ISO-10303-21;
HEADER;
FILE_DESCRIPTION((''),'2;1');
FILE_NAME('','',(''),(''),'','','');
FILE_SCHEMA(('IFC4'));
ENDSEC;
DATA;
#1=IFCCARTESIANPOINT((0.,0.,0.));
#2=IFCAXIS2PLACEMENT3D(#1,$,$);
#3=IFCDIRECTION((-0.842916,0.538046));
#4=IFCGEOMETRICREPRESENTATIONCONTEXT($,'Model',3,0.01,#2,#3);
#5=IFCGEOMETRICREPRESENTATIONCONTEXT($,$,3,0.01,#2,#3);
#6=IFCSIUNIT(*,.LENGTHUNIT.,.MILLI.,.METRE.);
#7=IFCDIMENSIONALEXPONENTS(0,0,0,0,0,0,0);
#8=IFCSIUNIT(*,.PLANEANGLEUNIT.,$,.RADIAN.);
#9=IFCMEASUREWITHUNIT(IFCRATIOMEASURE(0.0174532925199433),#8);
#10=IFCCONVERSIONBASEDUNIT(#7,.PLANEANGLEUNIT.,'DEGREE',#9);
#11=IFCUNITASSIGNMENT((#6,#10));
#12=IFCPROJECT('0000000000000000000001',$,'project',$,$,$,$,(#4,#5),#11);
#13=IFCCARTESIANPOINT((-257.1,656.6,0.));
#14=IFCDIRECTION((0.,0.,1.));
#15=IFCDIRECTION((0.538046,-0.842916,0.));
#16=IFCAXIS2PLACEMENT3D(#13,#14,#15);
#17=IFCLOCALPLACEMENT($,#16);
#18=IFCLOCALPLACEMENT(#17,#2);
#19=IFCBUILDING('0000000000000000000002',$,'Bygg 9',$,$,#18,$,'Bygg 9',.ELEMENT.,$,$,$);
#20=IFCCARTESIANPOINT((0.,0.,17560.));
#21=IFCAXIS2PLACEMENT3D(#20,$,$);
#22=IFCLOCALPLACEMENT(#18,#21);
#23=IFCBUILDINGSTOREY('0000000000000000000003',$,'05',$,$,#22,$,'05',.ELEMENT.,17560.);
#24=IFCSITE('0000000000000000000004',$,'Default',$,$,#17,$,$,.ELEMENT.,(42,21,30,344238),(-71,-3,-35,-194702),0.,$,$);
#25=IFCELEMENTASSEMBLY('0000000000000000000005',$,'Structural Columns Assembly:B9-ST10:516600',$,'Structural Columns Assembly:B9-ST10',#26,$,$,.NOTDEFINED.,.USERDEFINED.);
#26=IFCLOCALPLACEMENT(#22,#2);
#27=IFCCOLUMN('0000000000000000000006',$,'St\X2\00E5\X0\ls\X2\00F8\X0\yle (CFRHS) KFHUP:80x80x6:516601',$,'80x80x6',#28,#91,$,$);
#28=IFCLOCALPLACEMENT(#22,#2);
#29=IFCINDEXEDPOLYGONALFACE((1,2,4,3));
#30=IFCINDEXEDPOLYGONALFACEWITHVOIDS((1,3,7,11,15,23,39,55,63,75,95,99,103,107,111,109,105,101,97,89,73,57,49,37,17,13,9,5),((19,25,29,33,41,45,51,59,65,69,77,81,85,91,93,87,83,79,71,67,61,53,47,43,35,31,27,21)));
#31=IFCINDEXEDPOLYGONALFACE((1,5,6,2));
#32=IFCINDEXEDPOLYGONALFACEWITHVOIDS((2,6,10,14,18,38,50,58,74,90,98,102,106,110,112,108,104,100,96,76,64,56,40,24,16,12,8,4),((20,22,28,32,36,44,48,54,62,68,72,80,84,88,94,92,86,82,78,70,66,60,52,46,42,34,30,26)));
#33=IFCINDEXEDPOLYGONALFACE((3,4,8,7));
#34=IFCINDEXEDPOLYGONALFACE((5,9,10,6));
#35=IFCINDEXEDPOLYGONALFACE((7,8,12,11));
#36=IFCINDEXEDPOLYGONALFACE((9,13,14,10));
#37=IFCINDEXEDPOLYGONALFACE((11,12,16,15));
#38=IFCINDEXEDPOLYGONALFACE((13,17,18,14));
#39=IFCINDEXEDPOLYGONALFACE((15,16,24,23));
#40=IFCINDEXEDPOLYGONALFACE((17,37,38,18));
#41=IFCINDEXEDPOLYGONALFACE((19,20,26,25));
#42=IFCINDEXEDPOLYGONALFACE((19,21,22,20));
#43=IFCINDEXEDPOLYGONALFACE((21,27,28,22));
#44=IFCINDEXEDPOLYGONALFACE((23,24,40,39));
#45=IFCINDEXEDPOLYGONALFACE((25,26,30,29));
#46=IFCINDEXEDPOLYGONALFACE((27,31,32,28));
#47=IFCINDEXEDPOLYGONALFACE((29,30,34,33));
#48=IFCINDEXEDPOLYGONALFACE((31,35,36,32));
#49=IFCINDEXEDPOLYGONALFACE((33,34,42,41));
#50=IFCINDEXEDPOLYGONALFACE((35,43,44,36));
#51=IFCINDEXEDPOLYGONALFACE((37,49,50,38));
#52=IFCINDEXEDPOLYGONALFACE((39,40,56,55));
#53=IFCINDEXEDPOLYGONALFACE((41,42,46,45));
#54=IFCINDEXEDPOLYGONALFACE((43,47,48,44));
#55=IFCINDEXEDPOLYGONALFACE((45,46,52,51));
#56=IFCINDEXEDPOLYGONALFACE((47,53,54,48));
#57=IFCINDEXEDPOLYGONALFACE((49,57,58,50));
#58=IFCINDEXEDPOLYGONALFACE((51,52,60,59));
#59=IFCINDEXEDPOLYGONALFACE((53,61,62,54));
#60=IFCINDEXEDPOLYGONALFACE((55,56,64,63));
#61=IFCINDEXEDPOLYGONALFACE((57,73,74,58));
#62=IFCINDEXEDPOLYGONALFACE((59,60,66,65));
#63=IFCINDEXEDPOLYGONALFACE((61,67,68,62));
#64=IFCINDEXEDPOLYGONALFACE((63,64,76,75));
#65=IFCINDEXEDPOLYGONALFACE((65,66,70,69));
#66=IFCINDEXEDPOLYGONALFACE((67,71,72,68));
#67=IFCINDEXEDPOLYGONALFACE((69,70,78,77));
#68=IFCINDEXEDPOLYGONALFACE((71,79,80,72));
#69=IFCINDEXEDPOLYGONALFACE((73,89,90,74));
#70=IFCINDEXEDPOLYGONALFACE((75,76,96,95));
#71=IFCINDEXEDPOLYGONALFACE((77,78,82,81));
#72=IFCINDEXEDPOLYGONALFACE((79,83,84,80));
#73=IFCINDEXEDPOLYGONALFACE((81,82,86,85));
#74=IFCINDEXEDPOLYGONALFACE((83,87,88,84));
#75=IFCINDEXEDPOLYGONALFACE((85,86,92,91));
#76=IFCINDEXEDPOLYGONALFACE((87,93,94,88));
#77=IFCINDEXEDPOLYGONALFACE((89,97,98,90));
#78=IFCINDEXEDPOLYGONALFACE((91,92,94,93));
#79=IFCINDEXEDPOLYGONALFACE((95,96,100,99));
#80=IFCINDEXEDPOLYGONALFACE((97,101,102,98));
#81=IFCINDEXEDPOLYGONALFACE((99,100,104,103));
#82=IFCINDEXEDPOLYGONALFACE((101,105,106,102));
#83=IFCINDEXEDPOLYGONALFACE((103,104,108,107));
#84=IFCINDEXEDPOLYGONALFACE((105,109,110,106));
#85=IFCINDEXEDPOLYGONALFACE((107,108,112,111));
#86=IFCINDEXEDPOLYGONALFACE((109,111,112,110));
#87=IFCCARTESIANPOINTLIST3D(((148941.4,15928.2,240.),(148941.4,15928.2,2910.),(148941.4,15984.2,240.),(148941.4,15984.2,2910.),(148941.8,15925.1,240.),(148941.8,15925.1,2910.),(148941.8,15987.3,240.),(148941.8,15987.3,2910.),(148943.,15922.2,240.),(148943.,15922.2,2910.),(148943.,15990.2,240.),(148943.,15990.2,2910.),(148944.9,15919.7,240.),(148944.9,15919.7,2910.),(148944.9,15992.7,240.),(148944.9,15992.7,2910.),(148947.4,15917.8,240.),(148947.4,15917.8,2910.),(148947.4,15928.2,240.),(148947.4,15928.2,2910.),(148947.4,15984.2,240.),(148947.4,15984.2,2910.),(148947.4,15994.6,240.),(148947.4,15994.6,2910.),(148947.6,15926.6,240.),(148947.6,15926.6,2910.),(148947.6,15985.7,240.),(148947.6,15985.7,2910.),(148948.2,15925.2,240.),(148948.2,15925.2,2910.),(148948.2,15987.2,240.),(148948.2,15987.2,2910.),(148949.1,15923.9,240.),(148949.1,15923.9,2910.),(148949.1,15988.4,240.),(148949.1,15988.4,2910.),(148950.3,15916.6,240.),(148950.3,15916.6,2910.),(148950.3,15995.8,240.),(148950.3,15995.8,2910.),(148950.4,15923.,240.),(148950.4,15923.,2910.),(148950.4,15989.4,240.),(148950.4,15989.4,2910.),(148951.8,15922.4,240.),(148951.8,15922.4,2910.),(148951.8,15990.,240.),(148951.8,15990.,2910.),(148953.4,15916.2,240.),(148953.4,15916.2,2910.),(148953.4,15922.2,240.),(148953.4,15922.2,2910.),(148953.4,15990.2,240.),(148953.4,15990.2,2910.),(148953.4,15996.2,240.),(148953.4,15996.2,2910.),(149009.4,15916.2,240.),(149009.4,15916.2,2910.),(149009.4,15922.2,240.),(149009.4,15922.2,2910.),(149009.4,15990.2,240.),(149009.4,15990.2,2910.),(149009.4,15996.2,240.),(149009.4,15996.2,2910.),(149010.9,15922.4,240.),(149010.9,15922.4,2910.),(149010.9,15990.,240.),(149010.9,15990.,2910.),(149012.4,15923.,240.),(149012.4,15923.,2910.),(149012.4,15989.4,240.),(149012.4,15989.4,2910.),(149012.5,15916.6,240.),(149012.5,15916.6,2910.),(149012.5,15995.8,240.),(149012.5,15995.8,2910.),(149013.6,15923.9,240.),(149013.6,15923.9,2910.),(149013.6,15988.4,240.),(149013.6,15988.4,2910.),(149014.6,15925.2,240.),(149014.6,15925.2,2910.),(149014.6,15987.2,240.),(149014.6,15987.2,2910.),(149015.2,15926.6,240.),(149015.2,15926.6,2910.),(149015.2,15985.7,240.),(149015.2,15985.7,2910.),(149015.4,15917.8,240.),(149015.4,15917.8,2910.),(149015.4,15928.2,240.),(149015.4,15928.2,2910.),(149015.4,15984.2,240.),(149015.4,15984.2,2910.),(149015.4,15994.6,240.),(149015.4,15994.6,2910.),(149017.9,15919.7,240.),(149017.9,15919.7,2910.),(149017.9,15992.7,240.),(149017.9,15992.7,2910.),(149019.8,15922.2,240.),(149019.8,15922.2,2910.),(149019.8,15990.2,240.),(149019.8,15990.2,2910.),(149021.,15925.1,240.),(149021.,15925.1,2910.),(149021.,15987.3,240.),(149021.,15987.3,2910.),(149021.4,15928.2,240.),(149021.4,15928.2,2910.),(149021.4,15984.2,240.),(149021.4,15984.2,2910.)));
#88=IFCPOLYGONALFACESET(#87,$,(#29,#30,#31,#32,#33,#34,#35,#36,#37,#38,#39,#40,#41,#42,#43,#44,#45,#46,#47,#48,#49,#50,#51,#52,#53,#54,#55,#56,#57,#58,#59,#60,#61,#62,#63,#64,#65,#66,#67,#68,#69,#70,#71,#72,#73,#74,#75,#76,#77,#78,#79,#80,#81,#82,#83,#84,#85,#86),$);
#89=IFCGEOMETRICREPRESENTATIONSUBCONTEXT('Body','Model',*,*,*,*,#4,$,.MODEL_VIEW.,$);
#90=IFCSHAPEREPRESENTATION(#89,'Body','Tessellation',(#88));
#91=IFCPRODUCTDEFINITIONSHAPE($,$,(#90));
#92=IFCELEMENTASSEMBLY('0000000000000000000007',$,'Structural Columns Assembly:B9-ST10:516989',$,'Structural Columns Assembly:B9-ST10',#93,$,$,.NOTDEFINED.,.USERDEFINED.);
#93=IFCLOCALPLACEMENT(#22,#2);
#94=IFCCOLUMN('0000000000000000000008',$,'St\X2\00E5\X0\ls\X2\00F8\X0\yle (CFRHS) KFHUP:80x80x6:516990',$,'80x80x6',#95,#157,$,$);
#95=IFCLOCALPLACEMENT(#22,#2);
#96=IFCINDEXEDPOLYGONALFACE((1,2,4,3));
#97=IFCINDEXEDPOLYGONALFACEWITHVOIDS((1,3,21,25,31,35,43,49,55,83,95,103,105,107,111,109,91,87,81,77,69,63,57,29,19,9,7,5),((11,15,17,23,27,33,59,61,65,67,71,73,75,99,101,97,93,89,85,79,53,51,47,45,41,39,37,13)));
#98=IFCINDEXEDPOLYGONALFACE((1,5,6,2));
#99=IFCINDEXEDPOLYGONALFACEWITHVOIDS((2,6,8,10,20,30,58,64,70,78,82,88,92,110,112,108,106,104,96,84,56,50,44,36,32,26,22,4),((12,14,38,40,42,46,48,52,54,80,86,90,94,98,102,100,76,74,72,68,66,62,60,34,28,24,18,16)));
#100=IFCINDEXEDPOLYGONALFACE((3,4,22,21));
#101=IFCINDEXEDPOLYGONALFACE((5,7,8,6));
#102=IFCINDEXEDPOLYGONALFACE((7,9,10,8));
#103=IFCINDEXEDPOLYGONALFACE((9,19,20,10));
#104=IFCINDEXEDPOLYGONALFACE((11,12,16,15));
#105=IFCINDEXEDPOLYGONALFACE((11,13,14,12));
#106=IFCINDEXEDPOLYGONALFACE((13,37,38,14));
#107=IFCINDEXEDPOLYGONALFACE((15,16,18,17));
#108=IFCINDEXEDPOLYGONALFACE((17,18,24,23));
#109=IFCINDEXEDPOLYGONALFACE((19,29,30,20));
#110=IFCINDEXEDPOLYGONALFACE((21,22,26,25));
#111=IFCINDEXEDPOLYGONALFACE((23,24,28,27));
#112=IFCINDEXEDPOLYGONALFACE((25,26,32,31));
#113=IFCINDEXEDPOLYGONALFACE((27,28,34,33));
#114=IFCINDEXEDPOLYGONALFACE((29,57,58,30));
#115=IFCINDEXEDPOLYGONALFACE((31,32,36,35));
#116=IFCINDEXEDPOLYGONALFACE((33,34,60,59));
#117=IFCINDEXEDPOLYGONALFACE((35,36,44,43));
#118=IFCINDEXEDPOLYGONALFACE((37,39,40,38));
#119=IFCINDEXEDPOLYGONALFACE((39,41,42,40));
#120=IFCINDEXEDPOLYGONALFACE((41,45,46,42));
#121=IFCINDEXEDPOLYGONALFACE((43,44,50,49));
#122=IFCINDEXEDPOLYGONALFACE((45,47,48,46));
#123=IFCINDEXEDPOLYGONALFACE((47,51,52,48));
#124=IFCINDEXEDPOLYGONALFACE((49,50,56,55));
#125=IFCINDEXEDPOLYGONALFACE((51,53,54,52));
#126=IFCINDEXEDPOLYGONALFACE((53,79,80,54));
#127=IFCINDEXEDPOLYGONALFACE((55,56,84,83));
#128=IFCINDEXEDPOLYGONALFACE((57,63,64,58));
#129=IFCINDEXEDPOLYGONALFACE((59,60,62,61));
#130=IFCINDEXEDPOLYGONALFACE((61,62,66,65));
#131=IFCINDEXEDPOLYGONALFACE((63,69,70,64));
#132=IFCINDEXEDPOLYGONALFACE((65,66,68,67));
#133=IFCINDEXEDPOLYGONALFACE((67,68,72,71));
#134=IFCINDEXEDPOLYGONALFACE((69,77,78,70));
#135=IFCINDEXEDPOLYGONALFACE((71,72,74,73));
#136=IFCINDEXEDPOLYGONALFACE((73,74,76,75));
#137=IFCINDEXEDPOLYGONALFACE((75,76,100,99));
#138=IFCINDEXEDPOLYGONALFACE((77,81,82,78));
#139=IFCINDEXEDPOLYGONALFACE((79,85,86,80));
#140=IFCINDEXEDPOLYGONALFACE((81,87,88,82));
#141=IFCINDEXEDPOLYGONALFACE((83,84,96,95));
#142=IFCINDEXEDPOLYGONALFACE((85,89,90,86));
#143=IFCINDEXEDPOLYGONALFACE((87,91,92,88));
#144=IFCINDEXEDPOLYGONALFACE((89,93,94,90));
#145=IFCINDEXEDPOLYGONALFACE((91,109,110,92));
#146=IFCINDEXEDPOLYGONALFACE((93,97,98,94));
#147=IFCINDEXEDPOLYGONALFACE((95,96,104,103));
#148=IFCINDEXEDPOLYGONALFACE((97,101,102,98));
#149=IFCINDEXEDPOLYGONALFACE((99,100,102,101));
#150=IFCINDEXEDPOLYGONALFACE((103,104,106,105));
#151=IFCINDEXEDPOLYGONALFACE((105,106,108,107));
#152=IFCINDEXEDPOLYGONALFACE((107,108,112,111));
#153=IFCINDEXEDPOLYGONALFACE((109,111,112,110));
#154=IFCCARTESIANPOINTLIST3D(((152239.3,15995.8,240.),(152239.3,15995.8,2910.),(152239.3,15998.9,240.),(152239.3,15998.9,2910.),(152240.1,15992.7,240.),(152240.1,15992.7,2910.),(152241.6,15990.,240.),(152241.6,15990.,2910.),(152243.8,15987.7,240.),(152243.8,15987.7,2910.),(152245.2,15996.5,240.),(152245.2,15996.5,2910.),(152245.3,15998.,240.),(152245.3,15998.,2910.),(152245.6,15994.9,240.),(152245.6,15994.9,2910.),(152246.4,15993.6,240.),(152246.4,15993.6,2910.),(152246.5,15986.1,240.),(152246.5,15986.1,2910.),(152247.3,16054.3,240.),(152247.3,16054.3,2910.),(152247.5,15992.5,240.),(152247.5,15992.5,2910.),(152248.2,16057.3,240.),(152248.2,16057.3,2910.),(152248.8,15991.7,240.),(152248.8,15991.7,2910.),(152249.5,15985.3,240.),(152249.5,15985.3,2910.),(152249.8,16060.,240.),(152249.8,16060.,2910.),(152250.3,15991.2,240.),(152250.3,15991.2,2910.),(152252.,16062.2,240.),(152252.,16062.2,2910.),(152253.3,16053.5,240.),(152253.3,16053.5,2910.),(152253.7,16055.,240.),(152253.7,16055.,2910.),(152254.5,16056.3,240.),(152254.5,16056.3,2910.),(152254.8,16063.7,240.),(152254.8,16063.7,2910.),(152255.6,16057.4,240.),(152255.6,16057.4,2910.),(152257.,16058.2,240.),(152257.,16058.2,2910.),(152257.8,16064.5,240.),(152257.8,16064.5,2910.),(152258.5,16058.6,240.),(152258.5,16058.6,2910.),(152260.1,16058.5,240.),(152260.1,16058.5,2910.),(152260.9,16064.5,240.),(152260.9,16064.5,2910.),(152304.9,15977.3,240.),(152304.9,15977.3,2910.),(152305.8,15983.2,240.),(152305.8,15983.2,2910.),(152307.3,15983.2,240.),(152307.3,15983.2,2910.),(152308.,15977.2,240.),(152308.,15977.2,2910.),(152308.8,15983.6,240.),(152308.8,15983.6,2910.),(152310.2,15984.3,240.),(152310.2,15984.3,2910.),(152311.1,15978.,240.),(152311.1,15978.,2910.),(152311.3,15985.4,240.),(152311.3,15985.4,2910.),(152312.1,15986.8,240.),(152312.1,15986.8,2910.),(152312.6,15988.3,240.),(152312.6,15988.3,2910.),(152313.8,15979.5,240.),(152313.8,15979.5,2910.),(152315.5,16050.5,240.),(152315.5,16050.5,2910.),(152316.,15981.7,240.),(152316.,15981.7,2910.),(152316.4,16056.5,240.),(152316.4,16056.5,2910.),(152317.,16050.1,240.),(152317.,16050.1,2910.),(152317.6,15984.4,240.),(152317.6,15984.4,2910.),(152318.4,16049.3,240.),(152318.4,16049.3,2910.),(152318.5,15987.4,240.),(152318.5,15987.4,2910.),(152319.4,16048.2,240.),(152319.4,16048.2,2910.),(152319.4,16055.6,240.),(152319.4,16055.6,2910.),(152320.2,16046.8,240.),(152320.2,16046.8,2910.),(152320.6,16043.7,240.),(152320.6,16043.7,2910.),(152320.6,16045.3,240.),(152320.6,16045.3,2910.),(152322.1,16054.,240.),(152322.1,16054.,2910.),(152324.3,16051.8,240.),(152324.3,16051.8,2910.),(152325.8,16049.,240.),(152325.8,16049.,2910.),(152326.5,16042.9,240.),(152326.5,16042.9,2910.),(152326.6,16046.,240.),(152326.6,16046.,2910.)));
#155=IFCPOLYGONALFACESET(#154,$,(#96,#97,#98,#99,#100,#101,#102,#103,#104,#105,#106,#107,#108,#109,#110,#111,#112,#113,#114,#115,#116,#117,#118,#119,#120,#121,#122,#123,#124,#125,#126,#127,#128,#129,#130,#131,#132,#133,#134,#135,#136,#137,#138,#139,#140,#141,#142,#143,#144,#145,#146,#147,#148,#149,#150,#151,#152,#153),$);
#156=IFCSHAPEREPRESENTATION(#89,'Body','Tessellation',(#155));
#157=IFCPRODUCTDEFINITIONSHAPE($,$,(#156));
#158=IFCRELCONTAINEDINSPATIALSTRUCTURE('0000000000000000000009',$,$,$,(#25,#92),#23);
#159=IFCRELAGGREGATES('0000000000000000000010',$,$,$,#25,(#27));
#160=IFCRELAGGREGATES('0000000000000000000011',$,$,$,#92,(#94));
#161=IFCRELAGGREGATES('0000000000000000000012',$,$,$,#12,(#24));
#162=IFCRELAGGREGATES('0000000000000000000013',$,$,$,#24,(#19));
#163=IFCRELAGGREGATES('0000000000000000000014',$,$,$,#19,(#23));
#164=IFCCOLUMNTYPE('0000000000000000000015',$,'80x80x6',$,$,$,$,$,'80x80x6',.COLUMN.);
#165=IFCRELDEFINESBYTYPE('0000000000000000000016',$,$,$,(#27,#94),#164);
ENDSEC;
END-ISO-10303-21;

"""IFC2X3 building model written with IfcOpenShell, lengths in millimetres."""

from ifc_helpers import new_model, entity, si_unit, converted_unit, direction, frame, frame_2d, origin, place, context, subcontext, project, spatial, polyline, circle_curve, parameter, trimmed, segment, composite_curve, outline, extrude, source, transform, mapped, type_object, type_shapes, element, aggregate, save


model = new_model("IFC2X3")

# Units and contexts
model_context = context("Model", 3, precision=0.01, world=origin(), true_north=direction((-0.842916, 0.538046)))
context_of_model = context(None, 3, precision=0.01, world=origin(), true_north=direction((-0.842916, 0.538046)))
body_context = subcontext(model_context, "Body", "Model", "MODEL_VIEW")
ifc_project = project(units=[si_unit("LENGTHUNIT", "METRE", prefix="MILLI"), converted_unit("PLANEANGLEUNIT", "DEGREE", entity("IfcRatioMeasure", 0.0174532925199433), si_unit("PLANEANGLEUNIT", "RADIAN"), dimensions=[0, 0, 0, 0, 0, 0, 0])], contexts=[model_context, context_of_model])

# Site, building, storey
site_placement = place(None, frame((-257.1, 656.6, 0.0), z_axis=(0.0, 0.0, 1.0), x_axis=(0.538046, -0.842916, 0.0)))
site = spatial("IfcSite", under=ifc_project, at=site_placement, Name="Default", CompositionType="ELEMENT", RefLatitude=(42, 21, 30, 344238), RefLongitude=(-71, -3, -35, -194702), RefElevation=0.0)
building_placement = place(site_placement, origin())
building = spatial("IfcBuilding", under=site, at=building_placement, Name="Bygg 9", LongName="Bygg 9", CompositionType="ELEMENT")
storey_placement = place(building_placement, frame((0.0, 0.0, 17560.0)))
storey = spatial("IfcBuildingStorey", under=building, at=storey_placement, Name="05", LongName="05", CompositionType="ELEMENT", Elevation=17560.0)

# Element assemblies, columns
assembly_1_placement = place(storey_placement, origin())
assembly_1 = element("IfcElementAssembly", 1, at=assembly_1_placement, inside=storey, Name="Structural Columns Assembly:B9-ST10:516600", ObjectType="Structural Columns Assembly:B9-ST10", AssemblyPlace="NOTDEFINED", PredefinedType="USERDEFINED")
column_type = type_object("IfcColumnType", Name="80x80x6", ElementType="80x80x6", PredefinedType="COLUMN")
shared_shape_1 = source(origin(), body_context, "Body", "SweptSolid", [
    extrude(outline(composite_curve([segment(trimmed(circle_curve(frame_2d((-28.0, 28.0), x_axis=(1.0, 0.0)), 12.0), [parameter(90.0)], [parameter(180.0)], True, "PARAMETER"), True, "CONTINUOUS"), segment(polyline([(-40.0, 28.0), (-40.0, -28.0)]), True, "CONTINUOUS"), segment(trimmed(circle_curve(frame_2d((-28.0, -28.0), x_axis=(1.0, 0.0)), 12.0), [parameter(180.0)], [parameter(270.0)], True, "PARAMETER"), True, "CONTINUOUS"), segment(polyline([(-28.0, -40.0), (28.0, -40.0)]), True, "CONTINUOUS"), segment(trimmed(circle_curve(frame_2d((28.0, -28.0), x_axis=(1.0, 0.0)), 12.0), [parameter(270.0)], [parameter(0.0)], True, "PARAMETER"), True, "CONTINUOUS"), segment(polyline([(40.0, -28.0), (40.0, 28.0)]), True, "CONTINUOUS"), segment(trimmed(circle_curve(frame_2d((28.0, 28.0), x_axis=(1.0, 0.0)), 12.0), [parameter(0.0)], [parameter(90.0)], True, "PARAMETER"), True, "CONTINUOUS"), segment(polyline([(28.0, 40.0), (-28.0, 40.0)]), True, "CONTINUOUS")], self_intersect=False), holes=[composite_curve([segment(polyline([(-28.0, 34.0), (28.0, 34.0)]), True, "CONTINUOUS"), segment(trimmed(circle_curve(frame_2d((28.0, 28.0), x_axis=(1.0, 0.0)), 6.0), [parameter(360.0)], [parameter(90.0)], True, "PARAMETER"), False, "CONTINUOUS"), segment(polyline([(34.0, 28.0), (34.0, -28.0)]), True, "CONTINUOUS"), segment(trimmed(circle_curve(frame_2d((28.0, -28.0), x_axis=(1.0, 0.0)), 6.0), [parameter(270.0)], [parameter(360.0)], True, "PARAMETER"), False, "CONTINUOUS"), segment(polyline([(28.0, -34.0), (-28.0, -34.0)]), True, "CONTINUOUS"), segment(trimmed(circle_curve(frame_2d((-28.0, -28.0), x_axis=(1.0, 0.0)), 6.0), [parameter(180.0)], [parameter(270.0)], True, "PARAMETER"), False, "CONTINUOUS"), segment(polyline([(-34.0, -28.0), (-34.0, 28.0)]), True, "CONTINUOUS"), segment(trimmed(circle_curve(frame_2d((-28.0, 28.0), x_axis=(1.0, 0.0)), 6.0), [parameter(90.0)], [parameter(180.0)], True, "PARAMETER"), False, "CONTINUOUS")], self_intersect=False)]), frame((41.6, 41.6, 0.0), z_axis=(0.0, 0.0, 1.0), x_axis=(-1.0, 0.0, 0.0)), (0.0, 0.0, 1.0), 2670.0),
])
type_shapes(column_type, [shared_shape_1])
column_1_placement = place(assembly_1_placement, frame((149023.0, 15914.6, 240.0), z_axis=(0.0, 0.0, 1.0), x_axis=(0.0, 1.0, 0.0)))
column_1 = element("IfcColumn", 2, at=column_1_placement, type_object=column_type, Name="Stålsøyle (CFRHS) KFHUP:80x80x6:516601", ObjectType="80x80x6", context=body_context, shape_type="MappedRepresentation", body=[
    mapped(shared_shape_1, transform((0.0, 0.0, 0.0), scale=1.0)),
])
assembly_2_placement = place(storey_placement, origin())
assembly_2 = element("IfcElementAssembly", 3, at=assembly_2_placement, inside=storey, Name="Structural Columns Assembly:B9-ST10:516989", ObjectType="Structural Columns Assembly:B9-ST10", AssemblyPlace="NOTDEFINED", PredefinedType="USERDEFINED")
column_2_placement = place(assembly_2_placement, frame((152330.0, 16056.1, 240.0), z_axis=(0.0, 0.0, 1.0), x_axis=(-0.989691, 0.143216, 0.0)))
column_2 = element("IfcColumn", 4, at=column_2_placement, type_object=column_type, Name="Stålsøyle (CFRHS) KFHUP:80x80x6:516990", ObjectType="80x80x6", context=body_context, shape_type="MappedRepresentation", body=[
    mapped(shared_shape_1, transform((0.0, 0.0, 0.0), scale=1.0)),
])

aggregate(assembly_1, [column_1])
aggregate(assembly_2, [column_2])

save(model, "model.ifc")
